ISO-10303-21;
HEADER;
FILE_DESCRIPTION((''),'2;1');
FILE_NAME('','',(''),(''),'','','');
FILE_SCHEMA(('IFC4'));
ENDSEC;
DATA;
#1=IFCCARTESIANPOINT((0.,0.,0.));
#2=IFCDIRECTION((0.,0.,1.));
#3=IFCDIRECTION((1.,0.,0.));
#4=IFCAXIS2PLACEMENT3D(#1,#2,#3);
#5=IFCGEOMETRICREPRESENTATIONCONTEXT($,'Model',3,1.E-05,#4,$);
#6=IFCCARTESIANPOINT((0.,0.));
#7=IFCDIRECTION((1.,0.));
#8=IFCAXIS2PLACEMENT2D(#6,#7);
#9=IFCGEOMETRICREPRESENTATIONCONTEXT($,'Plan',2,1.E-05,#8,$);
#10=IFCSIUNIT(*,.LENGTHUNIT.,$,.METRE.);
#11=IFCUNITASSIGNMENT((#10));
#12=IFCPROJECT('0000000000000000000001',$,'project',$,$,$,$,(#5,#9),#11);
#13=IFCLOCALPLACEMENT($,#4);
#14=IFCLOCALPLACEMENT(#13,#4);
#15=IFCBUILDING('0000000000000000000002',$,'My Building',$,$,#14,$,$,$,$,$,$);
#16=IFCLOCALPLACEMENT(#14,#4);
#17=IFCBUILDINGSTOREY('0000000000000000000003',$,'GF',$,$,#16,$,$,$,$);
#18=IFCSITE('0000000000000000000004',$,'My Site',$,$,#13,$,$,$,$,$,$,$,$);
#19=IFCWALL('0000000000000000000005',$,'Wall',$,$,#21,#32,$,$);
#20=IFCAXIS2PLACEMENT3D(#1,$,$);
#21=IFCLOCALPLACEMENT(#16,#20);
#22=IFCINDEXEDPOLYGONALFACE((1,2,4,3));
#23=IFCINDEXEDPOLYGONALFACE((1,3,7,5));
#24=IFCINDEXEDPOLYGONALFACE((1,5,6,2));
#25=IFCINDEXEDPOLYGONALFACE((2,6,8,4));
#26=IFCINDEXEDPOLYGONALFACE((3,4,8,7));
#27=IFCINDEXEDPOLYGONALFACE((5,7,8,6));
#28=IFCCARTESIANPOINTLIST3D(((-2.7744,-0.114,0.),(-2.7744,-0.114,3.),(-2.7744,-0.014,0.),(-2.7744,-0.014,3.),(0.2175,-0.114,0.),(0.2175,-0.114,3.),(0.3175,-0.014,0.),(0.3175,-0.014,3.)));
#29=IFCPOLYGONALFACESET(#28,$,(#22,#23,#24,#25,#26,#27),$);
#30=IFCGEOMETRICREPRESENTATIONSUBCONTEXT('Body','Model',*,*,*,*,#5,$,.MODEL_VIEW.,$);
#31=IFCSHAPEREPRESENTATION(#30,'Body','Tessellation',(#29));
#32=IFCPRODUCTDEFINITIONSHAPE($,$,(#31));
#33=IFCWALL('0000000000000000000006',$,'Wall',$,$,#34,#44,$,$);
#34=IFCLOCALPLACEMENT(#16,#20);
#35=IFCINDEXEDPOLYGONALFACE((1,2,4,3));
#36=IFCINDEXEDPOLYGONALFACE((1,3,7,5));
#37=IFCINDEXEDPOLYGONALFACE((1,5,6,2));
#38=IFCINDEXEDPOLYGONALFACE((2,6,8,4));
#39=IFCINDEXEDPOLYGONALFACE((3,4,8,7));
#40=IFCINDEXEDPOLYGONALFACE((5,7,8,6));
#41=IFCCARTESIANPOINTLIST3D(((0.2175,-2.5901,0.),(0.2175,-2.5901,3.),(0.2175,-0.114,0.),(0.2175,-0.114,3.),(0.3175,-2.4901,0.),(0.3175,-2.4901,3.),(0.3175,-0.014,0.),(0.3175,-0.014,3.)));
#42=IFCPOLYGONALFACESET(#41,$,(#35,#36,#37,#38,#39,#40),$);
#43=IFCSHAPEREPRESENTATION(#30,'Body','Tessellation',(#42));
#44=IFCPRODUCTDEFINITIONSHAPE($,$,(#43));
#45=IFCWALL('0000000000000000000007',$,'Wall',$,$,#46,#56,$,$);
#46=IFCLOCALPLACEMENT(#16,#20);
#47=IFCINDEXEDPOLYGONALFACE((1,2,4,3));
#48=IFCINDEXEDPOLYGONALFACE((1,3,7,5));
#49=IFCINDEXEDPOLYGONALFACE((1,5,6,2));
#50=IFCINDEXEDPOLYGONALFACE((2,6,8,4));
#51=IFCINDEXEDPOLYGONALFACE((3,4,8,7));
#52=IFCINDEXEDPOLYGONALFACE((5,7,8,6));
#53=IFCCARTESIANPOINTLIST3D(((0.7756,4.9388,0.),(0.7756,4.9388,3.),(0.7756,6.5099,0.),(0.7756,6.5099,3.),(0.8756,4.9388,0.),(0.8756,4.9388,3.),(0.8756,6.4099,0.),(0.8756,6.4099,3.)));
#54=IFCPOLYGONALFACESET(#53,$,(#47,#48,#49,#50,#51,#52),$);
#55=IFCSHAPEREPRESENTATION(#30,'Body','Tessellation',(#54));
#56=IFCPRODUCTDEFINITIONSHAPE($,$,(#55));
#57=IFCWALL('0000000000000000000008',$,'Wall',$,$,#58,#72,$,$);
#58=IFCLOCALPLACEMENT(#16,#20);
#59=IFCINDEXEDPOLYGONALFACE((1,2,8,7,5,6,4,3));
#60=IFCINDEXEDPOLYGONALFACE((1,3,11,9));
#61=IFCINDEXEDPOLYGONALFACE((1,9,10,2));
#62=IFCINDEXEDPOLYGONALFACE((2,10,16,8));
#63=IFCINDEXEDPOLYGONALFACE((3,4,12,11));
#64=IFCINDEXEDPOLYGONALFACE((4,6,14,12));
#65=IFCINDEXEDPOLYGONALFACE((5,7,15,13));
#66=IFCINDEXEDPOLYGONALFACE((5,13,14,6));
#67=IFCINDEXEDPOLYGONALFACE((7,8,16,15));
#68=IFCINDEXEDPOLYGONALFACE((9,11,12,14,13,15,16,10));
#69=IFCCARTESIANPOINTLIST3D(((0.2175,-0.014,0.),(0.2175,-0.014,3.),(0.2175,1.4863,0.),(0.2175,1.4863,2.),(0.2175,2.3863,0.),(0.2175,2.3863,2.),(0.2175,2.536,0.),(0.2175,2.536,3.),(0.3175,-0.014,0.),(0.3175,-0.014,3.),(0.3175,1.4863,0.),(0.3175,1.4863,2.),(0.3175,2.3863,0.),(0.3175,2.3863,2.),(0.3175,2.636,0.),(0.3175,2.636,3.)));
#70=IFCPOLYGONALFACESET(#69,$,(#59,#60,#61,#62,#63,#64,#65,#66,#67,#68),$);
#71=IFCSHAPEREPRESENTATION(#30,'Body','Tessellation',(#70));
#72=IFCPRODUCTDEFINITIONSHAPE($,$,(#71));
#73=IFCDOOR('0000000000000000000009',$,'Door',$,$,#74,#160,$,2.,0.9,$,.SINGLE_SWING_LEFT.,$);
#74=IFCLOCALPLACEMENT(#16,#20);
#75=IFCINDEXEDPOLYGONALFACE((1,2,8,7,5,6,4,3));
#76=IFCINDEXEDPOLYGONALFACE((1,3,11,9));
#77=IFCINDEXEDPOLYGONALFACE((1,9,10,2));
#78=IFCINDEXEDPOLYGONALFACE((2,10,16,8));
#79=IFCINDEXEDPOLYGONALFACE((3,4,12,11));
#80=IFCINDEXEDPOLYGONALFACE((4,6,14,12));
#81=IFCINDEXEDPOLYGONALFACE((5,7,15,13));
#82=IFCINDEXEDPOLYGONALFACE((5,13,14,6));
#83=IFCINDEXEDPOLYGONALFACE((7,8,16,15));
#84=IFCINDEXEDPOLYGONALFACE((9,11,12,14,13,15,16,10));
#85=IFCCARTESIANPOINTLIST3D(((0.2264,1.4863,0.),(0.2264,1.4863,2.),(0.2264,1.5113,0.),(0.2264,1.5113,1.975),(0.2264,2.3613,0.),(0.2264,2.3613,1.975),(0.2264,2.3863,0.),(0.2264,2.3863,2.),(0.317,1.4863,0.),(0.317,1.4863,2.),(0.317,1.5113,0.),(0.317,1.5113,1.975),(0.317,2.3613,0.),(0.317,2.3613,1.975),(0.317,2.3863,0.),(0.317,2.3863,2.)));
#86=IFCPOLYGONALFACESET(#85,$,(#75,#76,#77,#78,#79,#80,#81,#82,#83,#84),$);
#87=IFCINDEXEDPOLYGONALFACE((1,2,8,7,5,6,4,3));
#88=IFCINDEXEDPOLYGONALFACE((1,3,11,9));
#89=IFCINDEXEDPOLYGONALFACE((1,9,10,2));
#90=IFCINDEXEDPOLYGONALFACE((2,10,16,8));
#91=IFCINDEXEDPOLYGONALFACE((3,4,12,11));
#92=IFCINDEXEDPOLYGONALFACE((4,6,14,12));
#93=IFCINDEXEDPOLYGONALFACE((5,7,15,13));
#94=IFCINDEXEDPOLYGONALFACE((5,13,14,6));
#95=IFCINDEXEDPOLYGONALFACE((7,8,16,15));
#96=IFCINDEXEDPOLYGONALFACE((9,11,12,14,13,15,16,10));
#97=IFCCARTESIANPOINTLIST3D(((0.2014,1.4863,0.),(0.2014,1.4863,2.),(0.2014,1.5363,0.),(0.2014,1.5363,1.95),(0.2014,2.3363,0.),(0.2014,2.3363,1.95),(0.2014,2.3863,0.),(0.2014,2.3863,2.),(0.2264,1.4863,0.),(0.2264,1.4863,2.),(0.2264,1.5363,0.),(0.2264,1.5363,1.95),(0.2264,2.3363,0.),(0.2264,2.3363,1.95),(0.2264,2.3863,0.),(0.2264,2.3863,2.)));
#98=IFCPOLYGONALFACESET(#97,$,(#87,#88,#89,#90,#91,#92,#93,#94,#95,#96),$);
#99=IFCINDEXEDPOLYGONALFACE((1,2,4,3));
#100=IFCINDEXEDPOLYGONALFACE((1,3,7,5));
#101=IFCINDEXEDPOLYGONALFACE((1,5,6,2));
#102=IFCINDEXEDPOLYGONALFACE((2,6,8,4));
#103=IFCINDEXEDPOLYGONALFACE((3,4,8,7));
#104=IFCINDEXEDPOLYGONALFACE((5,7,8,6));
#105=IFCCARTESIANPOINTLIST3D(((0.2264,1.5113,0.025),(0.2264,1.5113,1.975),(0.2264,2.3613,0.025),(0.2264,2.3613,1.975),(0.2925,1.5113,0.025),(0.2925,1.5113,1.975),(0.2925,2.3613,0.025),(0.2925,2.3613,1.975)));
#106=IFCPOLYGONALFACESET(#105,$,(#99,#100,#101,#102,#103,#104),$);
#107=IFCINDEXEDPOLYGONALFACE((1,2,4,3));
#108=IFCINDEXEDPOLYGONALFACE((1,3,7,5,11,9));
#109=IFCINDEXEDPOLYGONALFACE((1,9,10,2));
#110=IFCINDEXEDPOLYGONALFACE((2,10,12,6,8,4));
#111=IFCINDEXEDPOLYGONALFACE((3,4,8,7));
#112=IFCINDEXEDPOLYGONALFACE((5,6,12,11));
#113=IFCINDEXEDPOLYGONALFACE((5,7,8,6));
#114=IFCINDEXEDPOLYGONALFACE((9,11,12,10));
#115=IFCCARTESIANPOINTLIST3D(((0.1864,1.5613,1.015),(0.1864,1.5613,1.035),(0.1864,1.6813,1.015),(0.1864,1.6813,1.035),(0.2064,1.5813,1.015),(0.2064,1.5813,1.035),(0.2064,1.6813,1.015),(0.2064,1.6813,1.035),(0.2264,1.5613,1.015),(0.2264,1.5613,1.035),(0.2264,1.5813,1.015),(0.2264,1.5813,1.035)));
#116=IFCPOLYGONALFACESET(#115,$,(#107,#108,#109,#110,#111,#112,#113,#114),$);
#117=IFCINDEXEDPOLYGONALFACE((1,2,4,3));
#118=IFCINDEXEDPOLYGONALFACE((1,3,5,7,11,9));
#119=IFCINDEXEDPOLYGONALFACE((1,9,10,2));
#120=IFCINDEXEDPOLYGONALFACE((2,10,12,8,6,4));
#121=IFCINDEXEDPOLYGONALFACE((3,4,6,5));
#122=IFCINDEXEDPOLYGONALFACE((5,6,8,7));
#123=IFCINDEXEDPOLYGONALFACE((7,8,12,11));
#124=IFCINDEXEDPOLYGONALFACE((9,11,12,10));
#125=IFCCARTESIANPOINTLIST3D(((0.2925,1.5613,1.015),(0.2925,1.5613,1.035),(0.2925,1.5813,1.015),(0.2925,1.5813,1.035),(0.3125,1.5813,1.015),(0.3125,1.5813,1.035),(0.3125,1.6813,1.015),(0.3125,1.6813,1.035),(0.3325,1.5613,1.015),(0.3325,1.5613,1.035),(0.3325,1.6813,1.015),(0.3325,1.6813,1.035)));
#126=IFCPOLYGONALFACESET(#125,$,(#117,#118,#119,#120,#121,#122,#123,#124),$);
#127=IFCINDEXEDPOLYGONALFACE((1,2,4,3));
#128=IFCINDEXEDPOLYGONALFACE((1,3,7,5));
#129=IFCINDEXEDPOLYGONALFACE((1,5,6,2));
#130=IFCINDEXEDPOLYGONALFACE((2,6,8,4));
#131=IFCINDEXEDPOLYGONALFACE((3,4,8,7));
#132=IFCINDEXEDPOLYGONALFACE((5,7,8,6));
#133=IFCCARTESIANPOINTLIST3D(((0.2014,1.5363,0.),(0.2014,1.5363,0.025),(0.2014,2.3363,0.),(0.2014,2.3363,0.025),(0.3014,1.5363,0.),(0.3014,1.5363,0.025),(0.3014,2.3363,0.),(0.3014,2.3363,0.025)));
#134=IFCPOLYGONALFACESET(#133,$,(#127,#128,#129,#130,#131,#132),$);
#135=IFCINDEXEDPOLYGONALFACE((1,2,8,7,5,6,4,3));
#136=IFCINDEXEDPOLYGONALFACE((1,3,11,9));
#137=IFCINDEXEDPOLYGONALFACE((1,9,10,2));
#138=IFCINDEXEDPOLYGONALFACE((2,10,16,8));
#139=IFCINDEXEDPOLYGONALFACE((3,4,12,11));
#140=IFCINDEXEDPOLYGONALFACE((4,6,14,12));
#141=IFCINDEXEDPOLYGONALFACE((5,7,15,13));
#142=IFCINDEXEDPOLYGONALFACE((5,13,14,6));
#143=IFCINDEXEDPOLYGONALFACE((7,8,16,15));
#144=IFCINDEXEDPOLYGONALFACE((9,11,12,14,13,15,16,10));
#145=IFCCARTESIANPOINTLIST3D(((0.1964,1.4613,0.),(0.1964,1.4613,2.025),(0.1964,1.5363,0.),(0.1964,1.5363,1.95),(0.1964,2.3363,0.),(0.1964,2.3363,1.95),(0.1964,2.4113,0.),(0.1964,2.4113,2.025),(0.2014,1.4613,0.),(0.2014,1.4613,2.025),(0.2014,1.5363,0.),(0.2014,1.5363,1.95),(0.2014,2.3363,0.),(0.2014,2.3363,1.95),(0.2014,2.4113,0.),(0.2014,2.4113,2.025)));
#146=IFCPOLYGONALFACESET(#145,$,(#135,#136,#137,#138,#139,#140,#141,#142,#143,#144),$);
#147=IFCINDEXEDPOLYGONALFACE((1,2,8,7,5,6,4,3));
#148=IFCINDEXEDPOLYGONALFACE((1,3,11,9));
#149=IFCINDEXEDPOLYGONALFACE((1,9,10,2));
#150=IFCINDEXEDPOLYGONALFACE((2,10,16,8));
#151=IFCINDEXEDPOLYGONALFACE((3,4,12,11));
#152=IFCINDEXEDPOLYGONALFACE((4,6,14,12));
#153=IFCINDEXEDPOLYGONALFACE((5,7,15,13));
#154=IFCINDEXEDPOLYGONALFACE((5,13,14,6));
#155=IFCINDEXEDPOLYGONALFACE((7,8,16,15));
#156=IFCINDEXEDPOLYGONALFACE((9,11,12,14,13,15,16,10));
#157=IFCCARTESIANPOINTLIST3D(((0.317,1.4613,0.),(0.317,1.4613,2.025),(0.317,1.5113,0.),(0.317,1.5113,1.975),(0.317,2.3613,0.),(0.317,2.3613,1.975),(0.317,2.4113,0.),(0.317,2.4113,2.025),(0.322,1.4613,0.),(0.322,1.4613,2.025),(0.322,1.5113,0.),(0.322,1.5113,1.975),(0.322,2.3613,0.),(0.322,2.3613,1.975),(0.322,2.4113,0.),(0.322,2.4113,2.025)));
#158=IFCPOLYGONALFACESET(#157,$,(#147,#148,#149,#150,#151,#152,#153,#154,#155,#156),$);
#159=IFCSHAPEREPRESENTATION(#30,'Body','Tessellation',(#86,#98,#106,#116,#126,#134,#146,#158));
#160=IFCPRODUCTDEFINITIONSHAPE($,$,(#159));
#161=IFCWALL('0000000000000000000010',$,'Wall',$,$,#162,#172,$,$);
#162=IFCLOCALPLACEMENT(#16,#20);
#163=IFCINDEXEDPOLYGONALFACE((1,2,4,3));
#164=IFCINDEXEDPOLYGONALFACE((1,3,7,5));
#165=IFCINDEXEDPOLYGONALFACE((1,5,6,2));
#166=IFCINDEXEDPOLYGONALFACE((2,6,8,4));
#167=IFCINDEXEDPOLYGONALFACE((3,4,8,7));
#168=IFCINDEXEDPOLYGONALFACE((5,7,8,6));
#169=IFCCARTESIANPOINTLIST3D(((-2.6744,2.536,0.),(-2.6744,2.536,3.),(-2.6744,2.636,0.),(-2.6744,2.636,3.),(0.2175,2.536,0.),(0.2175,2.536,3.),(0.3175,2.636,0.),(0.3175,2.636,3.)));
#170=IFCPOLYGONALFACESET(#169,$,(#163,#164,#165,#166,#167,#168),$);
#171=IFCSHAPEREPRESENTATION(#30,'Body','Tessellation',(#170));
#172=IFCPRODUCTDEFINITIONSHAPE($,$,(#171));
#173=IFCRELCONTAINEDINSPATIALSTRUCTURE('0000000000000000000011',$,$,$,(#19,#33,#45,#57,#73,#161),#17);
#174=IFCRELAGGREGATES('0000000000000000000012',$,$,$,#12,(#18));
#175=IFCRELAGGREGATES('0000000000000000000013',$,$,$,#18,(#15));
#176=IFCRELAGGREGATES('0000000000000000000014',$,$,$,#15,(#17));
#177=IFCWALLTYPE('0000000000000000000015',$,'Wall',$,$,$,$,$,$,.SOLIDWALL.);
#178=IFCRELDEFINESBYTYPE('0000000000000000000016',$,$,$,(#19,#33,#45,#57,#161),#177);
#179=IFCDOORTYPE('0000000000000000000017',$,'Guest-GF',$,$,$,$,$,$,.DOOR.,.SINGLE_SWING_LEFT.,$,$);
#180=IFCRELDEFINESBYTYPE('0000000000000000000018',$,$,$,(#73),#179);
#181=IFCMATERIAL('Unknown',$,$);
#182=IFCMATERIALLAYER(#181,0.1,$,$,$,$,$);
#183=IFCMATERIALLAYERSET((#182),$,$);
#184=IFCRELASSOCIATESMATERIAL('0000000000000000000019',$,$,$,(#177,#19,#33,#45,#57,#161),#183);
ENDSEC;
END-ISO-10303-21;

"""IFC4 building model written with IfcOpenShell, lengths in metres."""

from ifc_helpers import new_model, entity, si_unit, frame, origin_with_axes, origin_2d_with_axis, place, context, subcontext, project, spatial, line, indexed_curve, outline, extrude, shape, source, transform, mapped, material, layer, layer_set, layer_usage, type_object, type_shapes, element, fill, save


model = new_model("IFC4")

# Units and contexts
model_context = context("Model", 3, precision=1e-05, world=origin_with_axes())
plan_context = context("Plan", 2, precision=1e-05, world=origin_2d_with_axis())
body_context_1 = subcontext(model_context, "Body", "Model", "MODEL_VIEW")
body_context_2 = subcontext(plan_context, "Body", "Plan", "PLAN_VIEW")
ifc_project = project(units=[si_unit("LENGTHUNIT", "METRE")], contexts=[model_context, plan_context])

# Site, building, storey
site_placement = place(None, origin_with_axes())
site = spatial("IfcSite", under=ifc_project, at=site_placement, Name="My Site")
building_placement = place(site_placement, origin_with_axes())
building = spatial("IfcBuilding", under=site, at=building_placement, Name="My Building")
storey_placement = place(building_placement, origin_with_axes())
storey = spatial("IfcBuildingStorey", under=building, at=storey_placement, Name="GF")

# Shared definitions
ifc_material = material(Name="Unknown")

# Shared definitions
ifc_layer_1 = layer(ifc_material, 0.1)
ifc_layer_set_1 = layer_set([ifc_layer_1])
wall_type = type_object("IfcWallType", Name="Wall", PredefinedType="SOLIDWALL", material=ifc_layer_set_1)

# Walls
ifc_layer_usage_1 = layer_usage(ifc_layer_set_1, "AXIS2", "POSITIVE", 0.0)
wall_1_placement = place(storey_placement, frame((-2.7744, -0.114, 0.0), z_axis=(0.0, 0.0, 1.0), x_axis=(1.0, 0.0, 0.0)))
element("IfcWall", 1, at=wall_1_placement, inside=storey, type_object=wall_type, material=ifc_layer_usage_1, Name="Wall", context=body_context_1, shape_type="SweptSolid", body=[
    extrude(outline(indexed_curve([(0.0, 0.0), (0.0, 0.1), (3.0919, 0.1), (2.9919, 0.0)], segments=[line(1, 2, 3, 4, 1)])), origin_with_axes(), (0.0, 0.0, 1.0), 3.0),
])
ifc_layer_usage_2 = layer_usage(ifc_layer_set_1, "AXIS2", "POSITIVE", 0.0)
wall_2_placement = place(storey_placement, frame((0.2175, -0.114, 0.0), z_axis=(0.0, 0.0, 1.0), x_axis=(0.0, -1.0, 0.0)))
element("IfcWall", 2, at=wall_2_placement, inside=storey, type_object=wall_type, material=ifc_layer_usage_2, Name="Wall", context=body_context_1, shape_type="SweptSolid", body=[
    extrude(outline(indexed_curve([(0.0, 0.0), (-0.1, 0.1), (2.3761, 0.1), (2.4761, 0.0)], segments=[line(1, 2, 3, 4, 1)])), origin_with_axes(), (0.0, 0.0, 1.0), 3.0),
])

# Wall
ifc_layer_usage_3 = layer_usage(ifc_layer_set_1, "AXIS2", "POSITIVE", 0.0)
wall_3_placement = place(storey_placement, frame((0.7756, 6.5099, 0.0), z_axis=(0.0, 0.0, 1.0), x_axis=(0.0, -1.0, 0.0)))
element("IfcWall", 3, at=wall_3_placement, inside=storey, type_object=wall_type, material=ifc_layer_usage_3, Name="Wall", context=body_context_1, shape_type="SweptSolid", body=[
    extrude(outline(indexed_curve([(0.0, 0.0), (0.1, 0.1), (1.5711, 0.1), (1.5711, 0.0)], segments=[line(1, 2, 3, 4, 1)])), origin_with_axes(), (0.0, 0.0, 1.0), 3.0),
])

# Wall, opening, door
ifc_layer_usage_4 = layer_usage(ifc_layer_set_1, "AXIS2", "POSITIVE", 0.0)
wall_4_placement = place(storey_placement, frame((0.3175, -0.114, 0.0), z_axis=(0.0, 0.0, 1.0), x_axis=(0.0, 1.0, 0.0)))
wall_4 = element("IfcWall", 4, at=wall_4_placement, inside=storey, type_object=wall_type, material=ifc_layer_usage_4, Name="Wall", context=body_context_1, shape_type="SweptSolid", body=[
    extrude(outline(indexed_curve([(0.1, 0.0), (0.1, 0.1), (2.65, 0.1), (2.75, 0.0)], segments=[line(1, 2, 3, 4, 1)])), origin_with_axes(), (0.0, 0.0, 1.0), 3.0),
])
shared_shape_1 = source(origin_with_axes(), body_context_1, "Body", "SweptSolid", [
    extrude(outline(indexed_curve([(0.0, 0.0), (0.9, 0.0), (0.9, 2.0), (0.0, 2.0)], segments=[line(1, 2, 3, 4, 1)])), frame((0.0, -0.6, 0.0), z_axis=(0.0, -1.0, 0.0), x_axis=(1.0, 0.0, 0.0)), (0.0, 0.0, -1.0), 1.2),
])
opening_1_placement = place(wall_4_placement, frame((2.5003, 0.1161, 0.0), z_axis=(0.0, 0.0, 1.0), x_axis=(-1.0, 0.0, 0.0)))
opening_1 = element("IfcOpeningElement", 5, at=opening_1_placement, cuts=wall_4, PredefinedType="OPENING", context=body_context_1, shape_type="MappedRepresentation", body=[
    mapped(shared_shape_1, transform((0.0, 0.0, 0.0), x_axis=(1.0, 0.0, 0.0), y_axis=(0.0, 1.0, 0.0), z_axis=(0.0, 0.0, 1.0), scale=1.0)),
])
door_type_1 = type_object("IfcDoorType", Name="Guest-GF", OperationType="SINGLE_SWING_LEFT", PredefinedType="DOOR")
shared_shape_2 = source(origin_with_axes(), body_context_1, "Body", "SweptSolid", [
    extrude(outline(indexed_curve([(0.0, 0.0), (0.0, 2.0), (0.9, 2.0), (0.9, 0.0), (0.875, 0.0), (0.875, 1.975), (0.025, 1.975), (0.025, 0.0)], segments=[line(1, 2, 3, 4, 5, 6, 7, 8, 1)])), frame((0.0, 0.025, 0.0), z_axis=(0.0, -1.0, 0.0), x_axis=(1.0, 0.0, 0.0)), (0.0, 0.0, -1.0), 0.0906),
    extrude(outline(indexed_curve([(0.0, 0.0), (0.0, 2.0), (0.9, 2.0), (0.9, 0.0), (0.85, 0.0), (0.85, 1.95), (0.05, 1.95), (0.05, 0.0)], segments=[line(1, 2, 3, 4, 5, 6, 7, 8, 1)])), frame((0.0, 0.0, 0.0), z_axis=(0.0, -1.0, 0.0), x_axis=(1.0, 0.0, 0.0)), (0.0, 0.0, -1.0), 0.025),
    extrude(outline(indexed_curve([(0.0, 0.0), (0.85, 0.0), (0.85, 0.0661), (0.0, 0.0661)], segments=[line(1, 2, 3, 4, 1)])), frame((0.025, 0.025, 0.025), z_axis=(0.0, 0.0, 1.0), x_axis=(1.0, 0.0, 0.0)), (0.0, 0.0, 1.0), 1.95),
    extrude(outline(indexed_curve([(0.0, 0.0), (0.0, -0.04), (-0.12, -0.04), (-0.12, -0.02), (-0.02, -0.02), (-0.02, 0.0)], segments=[line(1, 2, 3, 4, 5, 6, 1)])), frame((0.825, 0.025, 1.015), z_axis=(0.0, 0.0, 1.0), x_axis=(1.0, 0.0, 0.0)), (0.0, 0.0, 1.0), 0.02),
    extrude(outline(indexed_curve([(0.0, 0.0), (0.0, 0.04), (-0.12, 0.04), (-0.12, 0.02), (-0.02, 0.02), (-0.02, 0.0)], segments=[line(1, 2, 3, 4, 5, 6, 1)])), frame((0.825, 0.0911, 1.015), z_axis=(0.0, 0.0, 1.0), x_axis=(1.0, 0.0, 0.0)), (0.0, 0.0, 1.0), 0.02),
    extrude(outline(indexed_curve([(0.0, 0.0), (0.8, 0.0), (0.8, 0.1), (0.0, 0.1)], segments=[line(1, 2, 3, 4, 1)])), frame((0.05, 0.0, 0.0), z_axis=(0.0, 0.0, 1.0), x_axis=(1.0, 0.0, 0.0)), (0.0, 0.0, 1.0), 0.025),
    extrude(outline(indexed_curve([(0.0, 0.0), (0.0, 2.025), (0.95, 2.025), (0.95, 0.0), (0.875, 0.0), (0.875, 1.95), (0.075, 1.95), (0.075, 0.0)], segments=[line(1, 2, 3, 4, 5, 6, 7, 8, 1)])), frame((-0.025, -0.005, 0.0), z_axis=(0.0, -1.0, 0.0), x_axis=(1.0, 0.0, 0.0)), (0.0, 0.0, -1.0), 0.005),
    extrude(outline(indexed_curve([(0.0, 0.0), (0.0, 2.025), (0.95, 2.025), (0.95, 0.0), (0.9, 0.0), (0.9, 1.975), (0.05, 1.975), (0.05, 0.0)], segments=[line(1, 2, 3, 4, 5, 6, 7, 8, 1)])), frame((-0.025, 0.1156, 0.0), z_axis=(0.0, -1.0, 0.0), x_axis=(1.0, 0.0, 0.0)), (0.0, 0.0, -1.0), 0.005),
])
shared_shape_3 = source(origin_with_axes(), body_context_2, "Body", "Curve2D", [
    entity("IfcIndexedPolyCurve", entity("IfcCartesianPointList2D", [[0.0, 0.0], [0.0, 0.1156], [0.025, 0.1156], [0.025, 0.025], [0.05, 0.025], [0.05, 0.0]]), [entity("IfcLineIndex", [1, 2, 3, 4, 5, 6, 1])]),
    entity("IfcIndexedPolyCurve", entity("IfcCartesianPointList2D", [[0.9, 0.0], [0.9, 0.1156], [0.875, 0.1156], [0.875, 0.025], [0.85, 0.025], [0.85, 0.0]]), [entity("IfcLineIndex", [1, 2, 3, 4, 5, 6, 1])]),
    entity("IfcTrimmedCurve", entity("IfcEllipse", entity("IfcAxis2Placement2D", entity("IfcCartesianPoint", [0.0911, 0.1156]), entity("IfcDirection", [1.0, 0.0])), 0.7839, 0.85), [entity("IfcCartesianPoint", [0.875, 0.1156])], [entity("IfcCartesianPoint", [0.0911, 0.9656])], True, "CARTESIAN"),
    entity("IfcIndexedPolyCurve", entity("IfcCartesianPointList2D", [[0.025, 0.1156], [0.0911, 0.1156], [0.0911, 0.9656], [0.025, 0.9656]]), [entity("IfcLineIndex", [1, 2, 3, 4, 1])]),
])
type_shapes(door_type_1, [shared_shape_2, shared_shape_3])
door_1_placement = place(opening_1_placement, frame((0.0, 0.0, 0.0), z_axis=(0.0, 0.0, 1.0), x_axis=(1.0, 0.0, 0.0)))
door_1 = element("IfcDoor", 6, at=door_1_placement, inside=storey, type_object=door_type_1, Name="Door", OperationType="SINGLE_SWING_LEFT", OverallHeight=2.0, OverallWidth=0.9, shapes=[
    shape(body_context_1, "Body", "MappedRepresentation", [mapped(shared_shape_2, transform((0.0, 0.0, 0.0), x_axis=(1.0, 0.0, 0.0), y_axis=(0.0, 1.0, 0.0), z_axis=(0.0, 0.0, 1.0), scale=1.0))]),
    shape(body_context_2, "Body", "MappedRepresentation", [mapped(shared_shape_3, transform((0.0, 0.0, 0.0), x_axis=(1.0, 0.0, 0.0), y_axis=(0.0, 1.0, 0.0), z_axis=(0.0, 0.0, 1.0), scale=1.0))]),
])
fill(opening_1, door_1)

# Wall
ifc_layer_usage_5 = layer_usage(ifc_layer_set_1, "AXIS2", "POSITIVE", 0.0)
wall_5_placement = place(storey_placement, frame((0.3175, 2.636, 0.0), z_axis=(0.0, 0.0, 1.0), x_axis=(-1.0, 0.0, 0.0)))
element("IfcWall", 7, at=wall_5_placement, inside=storey, type_object=wall_type, material=ifc_layer_usage_5, Name="Wall", context=body_context_1, shape_type="SweptSolid", body=[
    extrude(outline(indexed_curve([(0.0, 0.0), (0.1, 0.1), (2.9919, 0.1), (2.9919, 0.0)], segments=[line(1, 2, 3, 4, 1)])), origin_with_axes(), (0.0, 0.0, 1.0), 3.0),
])

save(model, "model.ifc")
